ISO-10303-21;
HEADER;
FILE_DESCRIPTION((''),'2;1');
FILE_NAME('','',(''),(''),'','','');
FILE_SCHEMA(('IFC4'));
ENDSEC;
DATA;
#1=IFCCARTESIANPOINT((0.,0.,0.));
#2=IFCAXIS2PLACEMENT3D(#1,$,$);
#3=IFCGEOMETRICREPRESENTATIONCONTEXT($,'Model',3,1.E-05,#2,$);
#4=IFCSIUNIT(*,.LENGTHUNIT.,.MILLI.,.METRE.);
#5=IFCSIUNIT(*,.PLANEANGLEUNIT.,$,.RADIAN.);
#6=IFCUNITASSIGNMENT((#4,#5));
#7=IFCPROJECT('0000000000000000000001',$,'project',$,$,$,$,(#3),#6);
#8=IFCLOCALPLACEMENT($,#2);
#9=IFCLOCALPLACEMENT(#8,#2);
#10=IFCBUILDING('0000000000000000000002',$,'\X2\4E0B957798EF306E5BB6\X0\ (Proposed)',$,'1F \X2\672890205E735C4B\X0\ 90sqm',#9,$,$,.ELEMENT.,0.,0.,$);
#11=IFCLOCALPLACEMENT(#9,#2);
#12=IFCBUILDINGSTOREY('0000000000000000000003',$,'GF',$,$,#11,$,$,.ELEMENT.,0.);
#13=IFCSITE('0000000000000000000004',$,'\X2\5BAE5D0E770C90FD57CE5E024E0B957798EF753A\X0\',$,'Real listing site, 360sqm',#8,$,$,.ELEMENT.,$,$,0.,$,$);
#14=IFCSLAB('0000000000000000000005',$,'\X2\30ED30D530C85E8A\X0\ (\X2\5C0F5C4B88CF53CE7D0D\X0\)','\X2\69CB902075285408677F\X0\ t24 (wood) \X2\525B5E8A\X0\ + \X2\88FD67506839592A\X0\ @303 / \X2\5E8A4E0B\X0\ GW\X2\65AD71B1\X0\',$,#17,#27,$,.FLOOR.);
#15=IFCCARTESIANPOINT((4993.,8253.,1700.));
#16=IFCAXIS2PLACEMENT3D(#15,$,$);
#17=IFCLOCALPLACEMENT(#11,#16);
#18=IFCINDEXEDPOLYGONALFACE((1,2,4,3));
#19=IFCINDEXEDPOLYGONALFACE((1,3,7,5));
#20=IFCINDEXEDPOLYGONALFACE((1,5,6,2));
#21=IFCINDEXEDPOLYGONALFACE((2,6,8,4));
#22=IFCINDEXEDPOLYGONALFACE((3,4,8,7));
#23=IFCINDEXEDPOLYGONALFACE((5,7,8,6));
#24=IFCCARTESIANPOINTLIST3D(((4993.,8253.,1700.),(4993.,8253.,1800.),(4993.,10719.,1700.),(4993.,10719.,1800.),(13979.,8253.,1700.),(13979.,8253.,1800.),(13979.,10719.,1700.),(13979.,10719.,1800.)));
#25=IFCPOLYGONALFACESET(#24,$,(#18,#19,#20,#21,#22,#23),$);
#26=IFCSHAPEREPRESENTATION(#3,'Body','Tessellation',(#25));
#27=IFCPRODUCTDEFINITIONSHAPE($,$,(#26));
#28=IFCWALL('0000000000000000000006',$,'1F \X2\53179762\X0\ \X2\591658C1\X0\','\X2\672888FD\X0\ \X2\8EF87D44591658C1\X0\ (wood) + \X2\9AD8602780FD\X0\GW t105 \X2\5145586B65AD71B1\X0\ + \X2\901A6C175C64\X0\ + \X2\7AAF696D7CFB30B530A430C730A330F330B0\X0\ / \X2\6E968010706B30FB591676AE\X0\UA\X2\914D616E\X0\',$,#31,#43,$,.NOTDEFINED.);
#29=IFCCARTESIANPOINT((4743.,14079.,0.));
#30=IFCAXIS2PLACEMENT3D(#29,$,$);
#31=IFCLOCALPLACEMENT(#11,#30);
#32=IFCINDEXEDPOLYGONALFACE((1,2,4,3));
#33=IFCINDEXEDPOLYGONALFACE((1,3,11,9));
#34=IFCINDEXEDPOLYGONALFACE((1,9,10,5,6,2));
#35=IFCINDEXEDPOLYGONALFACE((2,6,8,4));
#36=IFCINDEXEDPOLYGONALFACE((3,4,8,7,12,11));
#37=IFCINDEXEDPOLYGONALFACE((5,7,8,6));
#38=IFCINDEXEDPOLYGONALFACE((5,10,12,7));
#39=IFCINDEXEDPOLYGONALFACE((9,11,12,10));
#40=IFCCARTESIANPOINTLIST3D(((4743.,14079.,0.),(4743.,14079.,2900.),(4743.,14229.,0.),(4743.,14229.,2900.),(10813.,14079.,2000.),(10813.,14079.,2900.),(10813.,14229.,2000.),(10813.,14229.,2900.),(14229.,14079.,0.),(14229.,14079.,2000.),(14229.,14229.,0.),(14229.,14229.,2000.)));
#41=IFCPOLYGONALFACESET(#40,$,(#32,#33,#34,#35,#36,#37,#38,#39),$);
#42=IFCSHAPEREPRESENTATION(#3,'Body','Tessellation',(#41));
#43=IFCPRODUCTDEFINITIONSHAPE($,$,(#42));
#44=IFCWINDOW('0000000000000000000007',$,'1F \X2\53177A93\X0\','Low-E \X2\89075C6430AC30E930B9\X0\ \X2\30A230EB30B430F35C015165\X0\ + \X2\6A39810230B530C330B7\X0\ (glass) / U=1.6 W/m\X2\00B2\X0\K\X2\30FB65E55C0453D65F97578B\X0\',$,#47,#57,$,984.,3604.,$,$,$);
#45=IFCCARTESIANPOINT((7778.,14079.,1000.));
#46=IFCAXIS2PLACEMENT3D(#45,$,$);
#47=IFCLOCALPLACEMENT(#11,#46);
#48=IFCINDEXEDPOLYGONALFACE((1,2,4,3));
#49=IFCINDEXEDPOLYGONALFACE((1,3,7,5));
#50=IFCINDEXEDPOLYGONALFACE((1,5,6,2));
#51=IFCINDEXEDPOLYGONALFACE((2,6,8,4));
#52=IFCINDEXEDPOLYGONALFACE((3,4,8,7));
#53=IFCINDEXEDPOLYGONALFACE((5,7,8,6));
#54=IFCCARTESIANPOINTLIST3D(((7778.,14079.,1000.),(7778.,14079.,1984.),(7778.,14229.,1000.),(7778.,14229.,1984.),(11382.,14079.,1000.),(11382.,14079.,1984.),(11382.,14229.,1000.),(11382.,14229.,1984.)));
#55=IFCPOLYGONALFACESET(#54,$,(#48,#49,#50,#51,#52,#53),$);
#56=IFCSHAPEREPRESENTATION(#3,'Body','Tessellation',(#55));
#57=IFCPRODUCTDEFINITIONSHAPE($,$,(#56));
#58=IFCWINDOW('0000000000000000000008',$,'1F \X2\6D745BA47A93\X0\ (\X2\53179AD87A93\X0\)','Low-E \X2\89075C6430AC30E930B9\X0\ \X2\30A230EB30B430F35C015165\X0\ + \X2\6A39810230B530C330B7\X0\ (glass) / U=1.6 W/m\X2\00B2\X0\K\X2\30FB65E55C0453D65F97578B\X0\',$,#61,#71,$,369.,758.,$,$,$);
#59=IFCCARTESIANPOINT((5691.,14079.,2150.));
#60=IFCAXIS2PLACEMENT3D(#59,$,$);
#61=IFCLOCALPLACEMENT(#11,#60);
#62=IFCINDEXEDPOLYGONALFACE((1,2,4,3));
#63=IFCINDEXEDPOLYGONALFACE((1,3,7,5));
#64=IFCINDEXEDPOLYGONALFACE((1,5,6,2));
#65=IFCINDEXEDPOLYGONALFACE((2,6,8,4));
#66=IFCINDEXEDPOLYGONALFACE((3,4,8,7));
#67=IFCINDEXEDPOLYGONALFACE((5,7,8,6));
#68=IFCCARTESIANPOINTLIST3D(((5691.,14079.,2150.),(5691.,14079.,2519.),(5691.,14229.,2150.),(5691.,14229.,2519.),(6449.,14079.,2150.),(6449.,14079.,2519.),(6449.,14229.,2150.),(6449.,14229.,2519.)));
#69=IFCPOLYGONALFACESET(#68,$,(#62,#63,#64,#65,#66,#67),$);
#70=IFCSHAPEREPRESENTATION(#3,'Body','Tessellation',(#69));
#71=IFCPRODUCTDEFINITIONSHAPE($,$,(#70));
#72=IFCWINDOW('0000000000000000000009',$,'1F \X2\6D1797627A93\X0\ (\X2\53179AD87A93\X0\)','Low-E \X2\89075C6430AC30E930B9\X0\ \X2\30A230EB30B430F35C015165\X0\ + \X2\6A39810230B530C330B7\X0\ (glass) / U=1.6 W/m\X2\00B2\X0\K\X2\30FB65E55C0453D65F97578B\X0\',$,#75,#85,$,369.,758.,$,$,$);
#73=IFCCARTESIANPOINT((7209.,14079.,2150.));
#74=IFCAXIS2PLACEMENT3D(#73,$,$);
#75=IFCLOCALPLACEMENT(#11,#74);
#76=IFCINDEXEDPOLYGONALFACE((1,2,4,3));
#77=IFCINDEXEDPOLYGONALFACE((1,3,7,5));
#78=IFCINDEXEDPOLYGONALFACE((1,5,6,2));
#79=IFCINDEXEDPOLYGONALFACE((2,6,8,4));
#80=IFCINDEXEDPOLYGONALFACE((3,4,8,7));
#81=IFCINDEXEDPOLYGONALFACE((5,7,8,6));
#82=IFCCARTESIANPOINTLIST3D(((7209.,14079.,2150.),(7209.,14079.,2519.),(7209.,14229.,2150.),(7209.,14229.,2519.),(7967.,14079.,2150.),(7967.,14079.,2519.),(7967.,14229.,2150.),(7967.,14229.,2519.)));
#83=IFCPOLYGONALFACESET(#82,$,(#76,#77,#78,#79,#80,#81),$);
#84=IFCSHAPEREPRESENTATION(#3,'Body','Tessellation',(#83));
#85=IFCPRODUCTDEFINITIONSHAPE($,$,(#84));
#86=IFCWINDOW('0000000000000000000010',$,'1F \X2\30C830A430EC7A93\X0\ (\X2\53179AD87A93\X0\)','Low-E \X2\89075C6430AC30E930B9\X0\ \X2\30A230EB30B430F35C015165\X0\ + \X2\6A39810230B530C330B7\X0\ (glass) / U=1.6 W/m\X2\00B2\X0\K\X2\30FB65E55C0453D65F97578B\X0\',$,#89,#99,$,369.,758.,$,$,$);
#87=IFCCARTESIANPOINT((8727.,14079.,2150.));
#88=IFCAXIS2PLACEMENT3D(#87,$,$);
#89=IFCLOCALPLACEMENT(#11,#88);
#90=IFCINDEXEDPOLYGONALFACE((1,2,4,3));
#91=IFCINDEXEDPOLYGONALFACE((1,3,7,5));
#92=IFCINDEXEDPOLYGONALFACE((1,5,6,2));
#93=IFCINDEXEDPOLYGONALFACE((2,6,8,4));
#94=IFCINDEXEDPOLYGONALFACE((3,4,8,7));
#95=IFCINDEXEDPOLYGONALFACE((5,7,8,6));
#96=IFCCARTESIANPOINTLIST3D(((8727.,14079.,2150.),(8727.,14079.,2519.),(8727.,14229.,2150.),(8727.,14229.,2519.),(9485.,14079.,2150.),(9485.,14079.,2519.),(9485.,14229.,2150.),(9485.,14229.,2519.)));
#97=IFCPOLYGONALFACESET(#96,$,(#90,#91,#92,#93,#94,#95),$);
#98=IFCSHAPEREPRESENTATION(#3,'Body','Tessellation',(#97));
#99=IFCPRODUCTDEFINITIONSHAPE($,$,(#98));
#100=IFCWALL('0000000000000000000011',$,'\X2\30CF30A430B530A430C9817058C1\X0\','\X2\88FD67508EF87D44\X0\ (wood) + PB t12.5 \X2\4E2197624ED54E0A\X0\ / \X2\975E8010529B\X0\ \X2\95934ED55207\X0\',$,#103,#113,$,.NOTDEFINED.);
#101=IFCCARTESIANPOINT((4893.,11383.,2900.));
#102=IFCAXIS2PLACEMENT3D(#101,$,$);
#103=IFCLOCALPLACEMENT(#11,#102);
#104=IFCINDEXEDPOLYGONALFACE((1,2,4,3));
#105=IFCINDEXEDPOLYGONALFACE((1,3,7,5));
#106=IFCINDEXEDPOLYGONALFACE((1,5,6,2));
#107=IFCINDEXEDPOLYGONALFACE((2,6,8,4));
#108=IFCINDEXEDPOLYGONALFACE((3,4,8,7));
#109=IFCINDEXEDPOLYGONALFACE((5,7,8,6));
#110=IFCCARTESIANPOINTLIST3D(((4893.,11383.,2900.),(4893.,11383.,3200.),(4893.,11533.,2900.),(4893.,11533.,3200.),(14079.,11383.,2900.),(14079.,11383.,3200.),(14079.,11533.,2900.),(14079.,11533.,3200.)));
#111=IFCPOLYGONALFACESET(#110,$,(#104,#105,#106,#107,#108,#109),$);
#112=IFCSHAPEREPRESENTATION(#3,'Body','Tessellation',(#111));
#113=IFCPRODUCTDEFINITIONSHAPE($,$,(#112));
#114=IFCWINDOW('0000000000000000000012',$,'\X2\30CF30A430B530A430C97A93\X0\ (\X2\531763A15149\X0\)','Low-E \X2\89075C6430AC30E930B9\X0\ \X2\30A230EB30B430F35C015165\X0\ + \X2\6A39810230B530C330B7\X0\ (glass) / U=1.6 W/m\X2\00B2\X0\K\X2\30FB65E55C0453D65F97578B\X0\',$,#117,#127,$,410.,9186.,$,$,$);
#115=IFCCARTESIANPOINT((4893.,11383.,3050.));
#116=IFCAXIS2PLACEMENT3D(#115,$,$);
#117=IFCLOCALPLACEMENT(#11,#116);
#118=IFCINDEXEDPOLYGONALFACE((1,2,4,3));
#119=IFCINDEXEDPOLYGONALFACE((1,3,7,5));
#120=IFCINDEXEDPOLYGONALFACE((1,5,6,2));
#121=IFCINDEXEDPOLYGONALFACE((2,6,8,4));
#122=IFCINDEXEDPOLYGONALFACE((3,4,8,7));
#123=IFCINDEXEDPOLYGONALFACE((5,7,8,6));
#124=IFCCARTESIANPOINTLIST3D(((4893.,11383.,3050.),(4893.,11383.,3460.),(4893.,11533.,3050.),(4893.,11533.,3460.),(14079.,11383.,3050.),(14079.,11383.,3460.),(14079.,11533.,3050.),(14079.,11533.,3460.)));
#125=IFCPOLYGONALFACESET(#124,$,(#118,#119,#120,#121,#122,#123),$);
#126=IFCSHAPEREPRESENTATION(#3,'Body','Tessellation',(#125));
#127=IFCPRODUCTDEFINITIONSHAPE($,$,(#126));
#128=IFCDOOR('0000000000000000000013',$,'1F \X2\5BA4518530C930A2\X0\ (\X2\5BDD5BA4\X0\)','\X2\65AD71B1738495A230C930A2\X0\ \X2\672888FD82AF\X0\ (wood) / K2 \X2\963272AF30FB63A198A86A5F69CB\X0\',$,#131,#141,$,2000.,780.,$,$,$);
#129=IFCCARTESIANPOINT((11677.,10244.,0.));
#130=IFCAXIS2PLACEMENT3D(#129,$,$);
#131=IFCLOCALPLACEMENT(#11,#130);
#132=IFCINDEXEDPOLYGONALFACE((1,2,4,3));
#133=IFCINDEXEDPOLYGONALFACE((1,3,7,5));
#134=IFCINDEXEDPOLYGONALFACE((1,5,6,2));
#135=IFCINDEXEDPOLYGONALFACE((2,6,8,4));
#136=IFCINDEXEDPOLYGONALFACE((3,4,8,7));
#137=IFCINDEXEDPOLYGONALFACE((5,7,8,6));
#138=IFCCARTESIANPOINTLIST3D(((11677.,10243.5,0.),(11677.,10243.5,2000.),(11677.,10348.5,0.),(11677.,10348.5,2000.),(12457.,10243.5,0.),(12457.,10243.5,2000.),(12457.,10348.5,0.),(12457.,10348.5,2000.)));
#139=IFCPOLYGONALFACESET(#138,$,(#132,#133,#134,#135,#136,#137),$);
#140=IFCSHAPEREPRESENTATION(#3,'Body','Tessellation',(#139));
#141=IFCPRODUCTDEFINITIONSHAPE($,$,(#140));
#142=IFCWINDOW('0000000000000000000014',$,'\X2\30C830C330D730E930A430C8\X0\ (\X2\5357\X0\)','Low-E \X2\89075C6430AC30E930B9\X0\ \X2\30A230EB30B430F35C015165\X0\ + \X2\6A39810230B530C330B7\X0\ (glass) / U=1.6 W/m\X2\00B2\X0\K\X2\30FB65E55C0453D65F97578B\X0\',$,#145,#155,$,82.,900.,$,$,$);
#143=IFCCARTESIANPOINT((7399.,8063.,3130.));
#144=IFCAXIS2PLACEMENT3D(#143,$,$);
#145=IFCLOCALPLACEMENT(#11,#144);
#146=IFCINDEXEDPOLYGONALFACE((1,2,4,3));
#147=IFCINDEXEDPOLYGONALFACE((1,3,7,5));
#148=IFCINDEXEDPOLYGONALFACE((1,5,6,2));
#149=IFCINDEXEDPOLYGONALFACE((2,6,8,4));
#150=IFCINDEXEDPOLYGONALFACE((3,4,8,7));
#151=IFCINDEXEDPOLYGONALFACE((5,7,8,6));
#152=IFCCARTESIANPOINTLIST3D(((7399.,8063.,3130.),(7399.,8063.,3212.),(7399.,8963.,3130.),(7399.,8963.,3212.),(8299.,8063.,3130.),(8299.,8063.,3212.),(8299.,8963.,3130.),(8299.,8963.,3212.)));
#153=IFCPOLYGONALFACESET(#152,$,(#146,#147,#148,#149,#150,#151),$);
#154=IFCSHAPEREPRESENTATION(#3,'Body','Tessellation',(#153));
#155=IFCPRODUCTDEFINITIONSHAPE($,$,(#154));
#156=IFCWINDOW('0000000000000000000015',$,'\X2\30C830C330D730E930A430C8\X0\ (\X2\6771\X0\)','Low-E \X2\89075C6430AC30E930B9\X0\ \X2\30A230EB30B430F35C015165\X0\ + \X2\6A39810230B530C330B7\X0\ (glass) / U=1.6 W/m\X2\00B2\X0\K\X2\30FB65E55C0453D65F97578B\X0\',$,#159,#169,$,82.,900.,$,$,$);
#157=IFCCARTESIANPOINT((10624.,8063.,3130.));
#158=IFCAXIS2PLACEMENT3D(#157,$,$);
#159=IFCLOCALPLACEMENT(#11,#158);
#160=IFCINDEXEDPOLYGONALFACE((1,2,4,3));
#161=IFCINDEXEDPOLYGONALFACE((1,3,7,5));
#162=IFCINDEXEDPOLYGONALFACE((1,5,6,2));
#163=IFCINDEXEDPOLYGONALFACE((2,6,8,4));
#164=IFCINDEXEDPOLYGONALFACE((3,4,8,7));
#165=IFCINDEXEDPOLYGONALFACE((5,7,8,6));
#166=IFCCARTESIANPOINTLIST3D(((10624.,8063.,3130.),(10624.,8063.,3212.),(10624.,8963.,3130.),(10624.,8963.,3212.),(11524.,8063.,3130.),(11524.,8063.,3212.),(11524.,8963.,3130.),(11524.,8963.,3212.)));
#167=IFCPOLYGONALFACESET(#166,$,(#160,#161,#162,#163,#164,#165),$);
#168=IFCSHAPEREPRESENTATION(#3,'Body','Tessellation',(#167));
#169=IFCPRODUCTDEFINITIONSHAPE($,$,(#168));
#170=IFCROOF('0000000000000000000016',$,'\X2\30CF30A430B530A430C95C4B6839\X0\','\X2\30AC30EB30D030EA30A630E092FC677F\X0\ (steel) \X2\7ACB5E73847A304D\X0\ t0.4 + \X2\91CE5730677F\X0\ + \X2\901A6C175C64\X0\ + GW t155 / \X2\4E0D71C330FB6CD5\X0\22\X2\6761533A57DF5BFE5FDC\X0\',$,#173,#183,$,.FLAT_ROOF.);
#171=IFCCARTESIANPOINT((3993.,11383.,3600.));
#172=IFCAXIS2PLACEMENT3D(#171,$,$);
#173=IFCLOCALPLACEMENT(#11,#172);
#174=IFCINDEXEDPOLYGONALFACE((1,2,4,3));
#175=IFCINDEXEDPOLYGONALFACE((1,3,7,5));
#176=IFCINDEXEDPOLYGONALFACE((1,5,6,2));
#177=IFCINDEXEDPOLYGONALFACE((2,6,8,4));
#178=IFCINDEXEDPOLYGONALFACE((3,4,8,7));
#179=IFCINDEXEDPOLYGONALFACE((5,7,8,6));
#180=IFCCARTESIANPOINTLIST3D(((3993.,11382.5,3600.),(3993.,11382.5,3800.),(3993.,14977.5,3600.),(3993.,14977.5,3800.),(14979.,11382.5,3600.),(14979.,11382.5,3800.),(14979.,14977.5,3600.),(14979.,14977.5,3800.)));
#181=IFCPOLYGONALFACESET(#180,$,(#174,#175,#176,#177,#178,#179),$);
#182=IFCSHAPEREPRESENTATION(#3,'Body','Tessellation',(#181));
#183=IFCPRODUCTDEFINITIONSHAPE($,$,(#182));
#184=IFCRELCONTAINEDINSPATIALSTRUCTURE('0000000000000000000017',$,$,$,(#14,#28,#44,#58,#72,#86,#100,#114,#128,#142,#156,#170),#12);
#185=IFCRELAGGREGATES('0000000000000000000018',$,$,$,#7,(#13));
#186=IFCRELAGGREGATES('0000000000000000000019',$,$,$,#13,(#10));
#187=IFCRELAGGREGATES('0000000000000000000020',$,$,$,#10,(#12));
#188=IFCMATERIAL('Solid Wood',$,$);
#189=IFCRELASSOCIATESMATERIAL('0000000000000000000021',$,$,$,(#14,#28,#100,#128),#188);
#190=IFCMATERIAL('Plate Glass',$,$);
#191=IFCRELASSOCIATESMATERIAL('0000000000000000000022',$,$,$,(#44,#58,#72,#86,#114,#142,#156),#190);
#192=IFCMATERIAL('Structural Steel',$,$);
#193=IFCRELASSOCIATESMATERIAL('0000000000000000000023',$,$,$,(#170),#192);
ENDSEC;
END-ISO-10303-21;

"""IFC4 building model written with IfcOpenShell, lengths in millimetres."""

from ifc_helpers import new_model, si_unit, frame, frame_2d, origin, place, context, project, spatial, rectangle, extrude, material, element, fill, save


model = new_model("IFC4")

# Units and contexts
model_context = context("Model", 3, precision=1e-05, world=origin())
ifc_project = project(units=[si_unit("LENGTHUNIT", "METRE", prefix="MILLI"), si_unit("PLANEANGLEUNIT", "RADIAN")], contexts=[model_context])

# Site, building, storey
site_placement = place(None, origin())
site = spatial("IfcSite", under=ifc_project, at=site_placement, Name="宮崎県都城市下長飯町", ObjectType="Real listing site, 360sqm", CompositionType="ELEMENT", RefElevation=0.0)
building_placement = place(site_placement, origin())
building = spatial("IfcBuilding", under=site, at=building_placement, Name="下長飯の家 (Proposed)", ObjectType="1F 木造平屋 90sqm", CompositionType="ELEMENT", ElevationOfRefHeight=0.0, ElevationOfTerrain=0.0)
storey_placement = place(building_placement, origin())
storey = spatial("IfcBuildingStorey", under=building, at=storey_placement, Name="GF", CompositionType="ELEMENT", Elevation=0.0)

# Slab
ifc_material_1 = material(Name="Solid Wood")
slab_placement = place(storey_placement, frame((4993.0, 8253.0, 1700.0)))
element("IfcSlab", 1, at=slab_placement, inside=storey, material=ifc_material_1, Name="ロフト床 (小屋裏収納)", Description="構造用合板 t24 (wood) 剛床 + 製材根太 @303 / 床下 GW断熱", PredefinedType="FLOOR", context=model_context, shape_type="SweptSolid", body=[
    extrude(rectangle(XDim=8986.0, YDim=2466.0, at=frame_2d((4493.0, 1233.0))), frame((4993.0, 8253.0, 1700.0)), (0.0, 0.0, 1.0), 100.0),
])

# Wall, openings, windows
wall_1_placement = place(storey_placement, frame((4743.0, 14079.0, 0.0)))
wall_1 = element("IfcWall", 2, at=wall_1_placement, inside=storey, material=ifc_material_1, Name="1F 北面 外壁", Description="木製 軸組外壁 (wood) + 高性能GW t105 充填断熱 + 通気層 + 窯業系サイディング / 準耐火・外皮UA配慮", PredefinedType="NOTDEFINED", context=model_context, shape_type="SweptSolid", body=[
    extrude(rectangle(XDim=9486.0, YDim=150.0, at=frame_2d((4743.0, 75.0))), frame((4743.0, 14079.0, 0.0)), (0.0, 0.0, 1.0), 2900.0),
])
opening_1_placement = place(storey_placement, frame((7778.0, 14079.0, 1000.0)))
opening_1 = element("IfcOpeningElement", 3, at=opening_1_placement, cuts=wall_1, PredefinedType="NOTDEFINED", context=model_context, shape_type="SweptSolid", body=[
    extrude(rectangle(XDim=3604.0, YDim=150.0, at=frame_2d((1802.0, 75.0))), frame((7778.0, 14079.0, 1000.0)), (0.0, 0.0, 1.0), 984.0),
])
opening_2_placement = place(storey_placement, frame((5691.0, 14079.0, 2150.0)))
opening_2 = element("IfcOpeningElement", 4, at=opening_2_placement, cuts=wall_1, PredefinedType="NOTDEFINED", context=model_context, shape_type="SweptSolid", body=[
    extrude(rectangle(XDim=758.0, YDim=150.0, at=frame_2d((379.0, 75.0))), frame((5691.0, 14079.0, 2150.0)), (0.0, 0.0, 1.0), 369.0),
])
opening_3_placement = place(storey_placement, frame((7209.0, 14079.0, 2150.0)))
opening_3 = element("IfcOpeningElement", 5, at=opening_3_placement, cuts=wall_1, PredefinedType="NOTDEFINED", context=model_context, shape_type="SweptSolid", body=[
    extrude(rectangle(XDim=758.0, YDim=150.0, at=frame_2d((379.0, 75.0))), frame((7209.0, 14079.0, 2150.0)), (0.0, 0.0, 1.0), 369.0),
])
opening_4_placement = place(storey_placement, frame((8727.0, 14079.0, 2150.0)))
opening_4 = element("IfcOpeningElement", 6, at=opening_4_placement, cuts=wall_1, PredefinedType="NOTDEFINED", context=model_context, shape_type="SweptSolid", body=[
    extrude(rectangle(XDim=758.0, YDim=150.0, at=frame_2d((379.0, 75.0))), frame((8727.0, 14079.0, 2150.0)), (0.0, 0.0, 1.0), 369.0),
])
ifc_material_2 = material(Name="Plate Glass")
window_1_placement = place(storey_placement, frame((7778.0, 14079.0, 1000.0)))
window_1 = element("IfcWindow", 7, at=window_1_placement, inside=storey, material=ifc_material_2, Name="1F 北窓", Description="Low-E 複層ガラス アルゴン封入 + 樹脂サッシ (glass) / U=1.6 W/m²K・日射取得型", OverallHeight=984.0, OverallWidth=3604.0, context=model_context, shape_type="SweptSolid", body=[
    extrude(rectangle(XDim=3604.0, YDim=150.0, at=frame_2d((1802.0, 75.0))), frame((7778.0, 14079.0, 1000.0)), (0.0, 0.0, 1.0), 984.0),
])
fill(opening_1, window_1)
window_2_placement = place(storey_placement, frame((5691.0, 14079.0, 2150.0)))
window_2 = element("IfcWindow", 8, at=window_2_placement, inside=storey, material=ifc_material_2, Name="1F 浴室窓 (北高窓)", Description="Low-E 複層ガラス アルゴン封入 + 樹脂サッシ (glass) / U=1.6 W/m²K・日射取得型", OverallHeight=369.0, OverallWidth=758.0, context=model_context, shape_type="SweptSolid", body=[
    extrude(rectangle(XDim=758.0, YDim=150.0, at=frame_2d((379.0, 75.0))), frame((5691.0, 14079.0, 2150.0)), (0.0, 0.0, 1.0), 369.0),
])
fill(opening_2, window_2)
window_3_placement = place(storey_placement, frame((7209.0, 14079.0, 2150.0)))
window_3 = element("IfcWindow", 9, at=window_3_placement, inside=storey, material=ifc_material_2, Name="1F 洗面窓 (北高窓)", Description="Low-E 複層ガラス アルゴン封入 + 樹脂サッシ (glass) / U=1.6 W/m²K・日射取得型", OverallHeight=369.0, OverallWidth=758.0, context=model_context, shape_type="SweptSolid", body=[
    extrude(rectangle(XDim=758.0, YDim=150.0, at=frame_2d((379.0, 75.0))), frame((7209.0, 14079.0, 2150.0)), (0.0, 0.0, 1.0), 369.0),
])
fill(opening_3, window_3)
window_4_placement = place(storey_placement, frame((8727.0, 14079.0, 2150.0)))
window_4 = element("IfcWindow", 10, at=window_4_placement, inside=storey, material=ifc_material_2, Name="1F トイレ窓 (北高窓)", Description="Low-E 複層ガラス アルゴン封入 + 樹脂サッシ (glass) / U=1.6 W/m²K・日射取得型", OverallHeight=369.0, OverallWidth=758.0, context=model_context, shape_type="SweptSolid", body=[
    extrude(rectangle(XDim=758.0, YDim=150.0, at=frame_2d((379.0, 75.0))), frame((8727.0, 14079.0, 2150.0)), (0.0, 0.0, 1.0), 369.0),
])
fill(opening_4, window_4)

# Wall, opening, window
wall_2_placement = place(storey_placement, frame((4893.0, 11383.0, 2900.0)))
wall_2 = element("IfcWall", 11, at=wall_2_placement, inside=storey, material=ifc_material_1, Name="ハイサイド腰壁", Description="製材軸組 (wood) + PB t12.5 両面仕上 / 非耐力 間仕切", PredefinedType="NOTDEFINED", context=model_context, shape_type="SweptSolid", body=[
    extrude(rectangle(XDim=9186.0, YDim=150.0, at=frame_2d((4593.0, 75.0))), frame((4893.0, 11383.0, 2900.0)), (0.0, 0.0, 1.0), 700.0),
])
opening_5_placement = place(storey_placement, frame((4893.0, 11383.0, 3050.0)))
opening_5 = element("IfcOpeningElement", 12, at=opening_5_placement, cuts=wall_2, PredefinedType="NOTDEFINED", context=model_context, shape_type="SweptSolid", body=[
    extrude(rectangle(XDim=9186.0, YDim=150.0, at=frame_2d((4593.0, 75.0))), frame((4893.0, 11383.0, 3050.0)), (0.0, 0.0, 1.0), 410.0),
])
window_5_placement = place(storey_placement, frame((4893.0, 11383.0, 3050.0)))
window_5 = element("IfcWindow", 13, at=window_5_placement, inside=storey, material=ifc_material_2, Name="ハイサイド窓 (北採光)", Description="Low-E 複層ガラス アルゴン封入 + 樹脂サッシ (glass) / U=1.6 W/m²K・日射取得型", OverallHeight=410.0, OverallWidth=9186.0, context=model_context, shape_type="SweptSolid", body=[
    extrude(rectangle(XDim=9186.0, YDim=150.0, at=frame_2d((4593.0, 75.0))), frame((4893.0, 11383.0, 3050.0)), (0.0, 0.0, 1.0), 410.0),
])
fill(opening_5, window_5)

# Door
door_1_placement = place(storey_placement, frame((11677.0, 10244.0, 0.0)))
element("IfcDoor", 14, at=door_1_placement, inside=storey, material=ifc_material_1, Name="1F 室内ドア (寝室)", Description="断熱玄関ドア 木製芯 (wood) / K2 防犯・採風機構", OverallHeight=2000.0, OverallWidth=780.0, context=model_context, shape_type="SweptSolid", body=[
    extrude(rectangle(XDim=780.0, YDim=105.0, at=frame_2d((390.0, 52.0))), frame((11677.0, 10244.0, 0.0)), (0.0, 0.0, 1.0), 2000.0),
])

# Windows
window_6_placement = place(storey_placement, frame((7399.0, 8063.0, 3130.0)))
element("IfcWindow", 15, at=window_6_placement, inside=storey, material=ifc_material_2, Name="トップライト (南)", Description="Low-E 複層ガラス アルゴン封入 + 樹脂サッシ (glass) / U=1.6 W/m²K・日射取得型", OverallHeight=82.0, OverallWidth=900.0, context=model_context, shape_type="SweptSolid", body=[
    extrude(rectangle(XDim=900.0, YDim=900.0, at=frame_2d((450.0, 450.0))), frame((7399.0, 8063.0, 3130.0)), (0.0, 0.0, 1.0), 82.0),
])
window_7_placement = place(storey_placement, frame((10624.0, 8063.0, 3130.0)))
element("IfcWindow", 16, at=window_7_placement, inside=storey, material=ifc_material_2, Name="トップライト (東)", Description="Low-E 複層ガラス アルゴン封入 + 樹脂サッシ (glass) / U=1.6 W/m²K・日射取得型", OverallHeight=82.0, OverallWidth=900.0, context=model_context, shape_type="SweptSolid", body=[
    extrude(rectangle(XDim=900.0, YDim=900.0, at=frame_2d((450.0, 450.0))), frame((10624.0, 8063.0, 3130.0)), (0.0, 0.0, 1.0), 82.0),
])

# Roof
ifc_material_3 = material(Name="Structural Steel")
roof_placement = place(storey_placement, frame((3993.0, 11383.0, 3600.0)))
element("IfcRoof", 17, at=roof_placement, inside=storey, material=ifc_material_3, Name="ハイサイド屋根", Description="ガルバリウム鋼板 (steel) 立平葺き t0.4 + 野地板 + 通気層 + GW t155 / 不燃・法22条区域対応", PredefinedType="FLAT_ROOF", context=model_context, shape_type="SweptSolid", body=[
    extrude(rectangle(XDim=10986.0, YDim=3595.0, at=frame_2d((5493.0, 1797.0))), frame((3993.0, 11383.0, 3600.0)), (0.0, 0.0, 1.0), 200.0),
])

save(model, "model.ifc")
